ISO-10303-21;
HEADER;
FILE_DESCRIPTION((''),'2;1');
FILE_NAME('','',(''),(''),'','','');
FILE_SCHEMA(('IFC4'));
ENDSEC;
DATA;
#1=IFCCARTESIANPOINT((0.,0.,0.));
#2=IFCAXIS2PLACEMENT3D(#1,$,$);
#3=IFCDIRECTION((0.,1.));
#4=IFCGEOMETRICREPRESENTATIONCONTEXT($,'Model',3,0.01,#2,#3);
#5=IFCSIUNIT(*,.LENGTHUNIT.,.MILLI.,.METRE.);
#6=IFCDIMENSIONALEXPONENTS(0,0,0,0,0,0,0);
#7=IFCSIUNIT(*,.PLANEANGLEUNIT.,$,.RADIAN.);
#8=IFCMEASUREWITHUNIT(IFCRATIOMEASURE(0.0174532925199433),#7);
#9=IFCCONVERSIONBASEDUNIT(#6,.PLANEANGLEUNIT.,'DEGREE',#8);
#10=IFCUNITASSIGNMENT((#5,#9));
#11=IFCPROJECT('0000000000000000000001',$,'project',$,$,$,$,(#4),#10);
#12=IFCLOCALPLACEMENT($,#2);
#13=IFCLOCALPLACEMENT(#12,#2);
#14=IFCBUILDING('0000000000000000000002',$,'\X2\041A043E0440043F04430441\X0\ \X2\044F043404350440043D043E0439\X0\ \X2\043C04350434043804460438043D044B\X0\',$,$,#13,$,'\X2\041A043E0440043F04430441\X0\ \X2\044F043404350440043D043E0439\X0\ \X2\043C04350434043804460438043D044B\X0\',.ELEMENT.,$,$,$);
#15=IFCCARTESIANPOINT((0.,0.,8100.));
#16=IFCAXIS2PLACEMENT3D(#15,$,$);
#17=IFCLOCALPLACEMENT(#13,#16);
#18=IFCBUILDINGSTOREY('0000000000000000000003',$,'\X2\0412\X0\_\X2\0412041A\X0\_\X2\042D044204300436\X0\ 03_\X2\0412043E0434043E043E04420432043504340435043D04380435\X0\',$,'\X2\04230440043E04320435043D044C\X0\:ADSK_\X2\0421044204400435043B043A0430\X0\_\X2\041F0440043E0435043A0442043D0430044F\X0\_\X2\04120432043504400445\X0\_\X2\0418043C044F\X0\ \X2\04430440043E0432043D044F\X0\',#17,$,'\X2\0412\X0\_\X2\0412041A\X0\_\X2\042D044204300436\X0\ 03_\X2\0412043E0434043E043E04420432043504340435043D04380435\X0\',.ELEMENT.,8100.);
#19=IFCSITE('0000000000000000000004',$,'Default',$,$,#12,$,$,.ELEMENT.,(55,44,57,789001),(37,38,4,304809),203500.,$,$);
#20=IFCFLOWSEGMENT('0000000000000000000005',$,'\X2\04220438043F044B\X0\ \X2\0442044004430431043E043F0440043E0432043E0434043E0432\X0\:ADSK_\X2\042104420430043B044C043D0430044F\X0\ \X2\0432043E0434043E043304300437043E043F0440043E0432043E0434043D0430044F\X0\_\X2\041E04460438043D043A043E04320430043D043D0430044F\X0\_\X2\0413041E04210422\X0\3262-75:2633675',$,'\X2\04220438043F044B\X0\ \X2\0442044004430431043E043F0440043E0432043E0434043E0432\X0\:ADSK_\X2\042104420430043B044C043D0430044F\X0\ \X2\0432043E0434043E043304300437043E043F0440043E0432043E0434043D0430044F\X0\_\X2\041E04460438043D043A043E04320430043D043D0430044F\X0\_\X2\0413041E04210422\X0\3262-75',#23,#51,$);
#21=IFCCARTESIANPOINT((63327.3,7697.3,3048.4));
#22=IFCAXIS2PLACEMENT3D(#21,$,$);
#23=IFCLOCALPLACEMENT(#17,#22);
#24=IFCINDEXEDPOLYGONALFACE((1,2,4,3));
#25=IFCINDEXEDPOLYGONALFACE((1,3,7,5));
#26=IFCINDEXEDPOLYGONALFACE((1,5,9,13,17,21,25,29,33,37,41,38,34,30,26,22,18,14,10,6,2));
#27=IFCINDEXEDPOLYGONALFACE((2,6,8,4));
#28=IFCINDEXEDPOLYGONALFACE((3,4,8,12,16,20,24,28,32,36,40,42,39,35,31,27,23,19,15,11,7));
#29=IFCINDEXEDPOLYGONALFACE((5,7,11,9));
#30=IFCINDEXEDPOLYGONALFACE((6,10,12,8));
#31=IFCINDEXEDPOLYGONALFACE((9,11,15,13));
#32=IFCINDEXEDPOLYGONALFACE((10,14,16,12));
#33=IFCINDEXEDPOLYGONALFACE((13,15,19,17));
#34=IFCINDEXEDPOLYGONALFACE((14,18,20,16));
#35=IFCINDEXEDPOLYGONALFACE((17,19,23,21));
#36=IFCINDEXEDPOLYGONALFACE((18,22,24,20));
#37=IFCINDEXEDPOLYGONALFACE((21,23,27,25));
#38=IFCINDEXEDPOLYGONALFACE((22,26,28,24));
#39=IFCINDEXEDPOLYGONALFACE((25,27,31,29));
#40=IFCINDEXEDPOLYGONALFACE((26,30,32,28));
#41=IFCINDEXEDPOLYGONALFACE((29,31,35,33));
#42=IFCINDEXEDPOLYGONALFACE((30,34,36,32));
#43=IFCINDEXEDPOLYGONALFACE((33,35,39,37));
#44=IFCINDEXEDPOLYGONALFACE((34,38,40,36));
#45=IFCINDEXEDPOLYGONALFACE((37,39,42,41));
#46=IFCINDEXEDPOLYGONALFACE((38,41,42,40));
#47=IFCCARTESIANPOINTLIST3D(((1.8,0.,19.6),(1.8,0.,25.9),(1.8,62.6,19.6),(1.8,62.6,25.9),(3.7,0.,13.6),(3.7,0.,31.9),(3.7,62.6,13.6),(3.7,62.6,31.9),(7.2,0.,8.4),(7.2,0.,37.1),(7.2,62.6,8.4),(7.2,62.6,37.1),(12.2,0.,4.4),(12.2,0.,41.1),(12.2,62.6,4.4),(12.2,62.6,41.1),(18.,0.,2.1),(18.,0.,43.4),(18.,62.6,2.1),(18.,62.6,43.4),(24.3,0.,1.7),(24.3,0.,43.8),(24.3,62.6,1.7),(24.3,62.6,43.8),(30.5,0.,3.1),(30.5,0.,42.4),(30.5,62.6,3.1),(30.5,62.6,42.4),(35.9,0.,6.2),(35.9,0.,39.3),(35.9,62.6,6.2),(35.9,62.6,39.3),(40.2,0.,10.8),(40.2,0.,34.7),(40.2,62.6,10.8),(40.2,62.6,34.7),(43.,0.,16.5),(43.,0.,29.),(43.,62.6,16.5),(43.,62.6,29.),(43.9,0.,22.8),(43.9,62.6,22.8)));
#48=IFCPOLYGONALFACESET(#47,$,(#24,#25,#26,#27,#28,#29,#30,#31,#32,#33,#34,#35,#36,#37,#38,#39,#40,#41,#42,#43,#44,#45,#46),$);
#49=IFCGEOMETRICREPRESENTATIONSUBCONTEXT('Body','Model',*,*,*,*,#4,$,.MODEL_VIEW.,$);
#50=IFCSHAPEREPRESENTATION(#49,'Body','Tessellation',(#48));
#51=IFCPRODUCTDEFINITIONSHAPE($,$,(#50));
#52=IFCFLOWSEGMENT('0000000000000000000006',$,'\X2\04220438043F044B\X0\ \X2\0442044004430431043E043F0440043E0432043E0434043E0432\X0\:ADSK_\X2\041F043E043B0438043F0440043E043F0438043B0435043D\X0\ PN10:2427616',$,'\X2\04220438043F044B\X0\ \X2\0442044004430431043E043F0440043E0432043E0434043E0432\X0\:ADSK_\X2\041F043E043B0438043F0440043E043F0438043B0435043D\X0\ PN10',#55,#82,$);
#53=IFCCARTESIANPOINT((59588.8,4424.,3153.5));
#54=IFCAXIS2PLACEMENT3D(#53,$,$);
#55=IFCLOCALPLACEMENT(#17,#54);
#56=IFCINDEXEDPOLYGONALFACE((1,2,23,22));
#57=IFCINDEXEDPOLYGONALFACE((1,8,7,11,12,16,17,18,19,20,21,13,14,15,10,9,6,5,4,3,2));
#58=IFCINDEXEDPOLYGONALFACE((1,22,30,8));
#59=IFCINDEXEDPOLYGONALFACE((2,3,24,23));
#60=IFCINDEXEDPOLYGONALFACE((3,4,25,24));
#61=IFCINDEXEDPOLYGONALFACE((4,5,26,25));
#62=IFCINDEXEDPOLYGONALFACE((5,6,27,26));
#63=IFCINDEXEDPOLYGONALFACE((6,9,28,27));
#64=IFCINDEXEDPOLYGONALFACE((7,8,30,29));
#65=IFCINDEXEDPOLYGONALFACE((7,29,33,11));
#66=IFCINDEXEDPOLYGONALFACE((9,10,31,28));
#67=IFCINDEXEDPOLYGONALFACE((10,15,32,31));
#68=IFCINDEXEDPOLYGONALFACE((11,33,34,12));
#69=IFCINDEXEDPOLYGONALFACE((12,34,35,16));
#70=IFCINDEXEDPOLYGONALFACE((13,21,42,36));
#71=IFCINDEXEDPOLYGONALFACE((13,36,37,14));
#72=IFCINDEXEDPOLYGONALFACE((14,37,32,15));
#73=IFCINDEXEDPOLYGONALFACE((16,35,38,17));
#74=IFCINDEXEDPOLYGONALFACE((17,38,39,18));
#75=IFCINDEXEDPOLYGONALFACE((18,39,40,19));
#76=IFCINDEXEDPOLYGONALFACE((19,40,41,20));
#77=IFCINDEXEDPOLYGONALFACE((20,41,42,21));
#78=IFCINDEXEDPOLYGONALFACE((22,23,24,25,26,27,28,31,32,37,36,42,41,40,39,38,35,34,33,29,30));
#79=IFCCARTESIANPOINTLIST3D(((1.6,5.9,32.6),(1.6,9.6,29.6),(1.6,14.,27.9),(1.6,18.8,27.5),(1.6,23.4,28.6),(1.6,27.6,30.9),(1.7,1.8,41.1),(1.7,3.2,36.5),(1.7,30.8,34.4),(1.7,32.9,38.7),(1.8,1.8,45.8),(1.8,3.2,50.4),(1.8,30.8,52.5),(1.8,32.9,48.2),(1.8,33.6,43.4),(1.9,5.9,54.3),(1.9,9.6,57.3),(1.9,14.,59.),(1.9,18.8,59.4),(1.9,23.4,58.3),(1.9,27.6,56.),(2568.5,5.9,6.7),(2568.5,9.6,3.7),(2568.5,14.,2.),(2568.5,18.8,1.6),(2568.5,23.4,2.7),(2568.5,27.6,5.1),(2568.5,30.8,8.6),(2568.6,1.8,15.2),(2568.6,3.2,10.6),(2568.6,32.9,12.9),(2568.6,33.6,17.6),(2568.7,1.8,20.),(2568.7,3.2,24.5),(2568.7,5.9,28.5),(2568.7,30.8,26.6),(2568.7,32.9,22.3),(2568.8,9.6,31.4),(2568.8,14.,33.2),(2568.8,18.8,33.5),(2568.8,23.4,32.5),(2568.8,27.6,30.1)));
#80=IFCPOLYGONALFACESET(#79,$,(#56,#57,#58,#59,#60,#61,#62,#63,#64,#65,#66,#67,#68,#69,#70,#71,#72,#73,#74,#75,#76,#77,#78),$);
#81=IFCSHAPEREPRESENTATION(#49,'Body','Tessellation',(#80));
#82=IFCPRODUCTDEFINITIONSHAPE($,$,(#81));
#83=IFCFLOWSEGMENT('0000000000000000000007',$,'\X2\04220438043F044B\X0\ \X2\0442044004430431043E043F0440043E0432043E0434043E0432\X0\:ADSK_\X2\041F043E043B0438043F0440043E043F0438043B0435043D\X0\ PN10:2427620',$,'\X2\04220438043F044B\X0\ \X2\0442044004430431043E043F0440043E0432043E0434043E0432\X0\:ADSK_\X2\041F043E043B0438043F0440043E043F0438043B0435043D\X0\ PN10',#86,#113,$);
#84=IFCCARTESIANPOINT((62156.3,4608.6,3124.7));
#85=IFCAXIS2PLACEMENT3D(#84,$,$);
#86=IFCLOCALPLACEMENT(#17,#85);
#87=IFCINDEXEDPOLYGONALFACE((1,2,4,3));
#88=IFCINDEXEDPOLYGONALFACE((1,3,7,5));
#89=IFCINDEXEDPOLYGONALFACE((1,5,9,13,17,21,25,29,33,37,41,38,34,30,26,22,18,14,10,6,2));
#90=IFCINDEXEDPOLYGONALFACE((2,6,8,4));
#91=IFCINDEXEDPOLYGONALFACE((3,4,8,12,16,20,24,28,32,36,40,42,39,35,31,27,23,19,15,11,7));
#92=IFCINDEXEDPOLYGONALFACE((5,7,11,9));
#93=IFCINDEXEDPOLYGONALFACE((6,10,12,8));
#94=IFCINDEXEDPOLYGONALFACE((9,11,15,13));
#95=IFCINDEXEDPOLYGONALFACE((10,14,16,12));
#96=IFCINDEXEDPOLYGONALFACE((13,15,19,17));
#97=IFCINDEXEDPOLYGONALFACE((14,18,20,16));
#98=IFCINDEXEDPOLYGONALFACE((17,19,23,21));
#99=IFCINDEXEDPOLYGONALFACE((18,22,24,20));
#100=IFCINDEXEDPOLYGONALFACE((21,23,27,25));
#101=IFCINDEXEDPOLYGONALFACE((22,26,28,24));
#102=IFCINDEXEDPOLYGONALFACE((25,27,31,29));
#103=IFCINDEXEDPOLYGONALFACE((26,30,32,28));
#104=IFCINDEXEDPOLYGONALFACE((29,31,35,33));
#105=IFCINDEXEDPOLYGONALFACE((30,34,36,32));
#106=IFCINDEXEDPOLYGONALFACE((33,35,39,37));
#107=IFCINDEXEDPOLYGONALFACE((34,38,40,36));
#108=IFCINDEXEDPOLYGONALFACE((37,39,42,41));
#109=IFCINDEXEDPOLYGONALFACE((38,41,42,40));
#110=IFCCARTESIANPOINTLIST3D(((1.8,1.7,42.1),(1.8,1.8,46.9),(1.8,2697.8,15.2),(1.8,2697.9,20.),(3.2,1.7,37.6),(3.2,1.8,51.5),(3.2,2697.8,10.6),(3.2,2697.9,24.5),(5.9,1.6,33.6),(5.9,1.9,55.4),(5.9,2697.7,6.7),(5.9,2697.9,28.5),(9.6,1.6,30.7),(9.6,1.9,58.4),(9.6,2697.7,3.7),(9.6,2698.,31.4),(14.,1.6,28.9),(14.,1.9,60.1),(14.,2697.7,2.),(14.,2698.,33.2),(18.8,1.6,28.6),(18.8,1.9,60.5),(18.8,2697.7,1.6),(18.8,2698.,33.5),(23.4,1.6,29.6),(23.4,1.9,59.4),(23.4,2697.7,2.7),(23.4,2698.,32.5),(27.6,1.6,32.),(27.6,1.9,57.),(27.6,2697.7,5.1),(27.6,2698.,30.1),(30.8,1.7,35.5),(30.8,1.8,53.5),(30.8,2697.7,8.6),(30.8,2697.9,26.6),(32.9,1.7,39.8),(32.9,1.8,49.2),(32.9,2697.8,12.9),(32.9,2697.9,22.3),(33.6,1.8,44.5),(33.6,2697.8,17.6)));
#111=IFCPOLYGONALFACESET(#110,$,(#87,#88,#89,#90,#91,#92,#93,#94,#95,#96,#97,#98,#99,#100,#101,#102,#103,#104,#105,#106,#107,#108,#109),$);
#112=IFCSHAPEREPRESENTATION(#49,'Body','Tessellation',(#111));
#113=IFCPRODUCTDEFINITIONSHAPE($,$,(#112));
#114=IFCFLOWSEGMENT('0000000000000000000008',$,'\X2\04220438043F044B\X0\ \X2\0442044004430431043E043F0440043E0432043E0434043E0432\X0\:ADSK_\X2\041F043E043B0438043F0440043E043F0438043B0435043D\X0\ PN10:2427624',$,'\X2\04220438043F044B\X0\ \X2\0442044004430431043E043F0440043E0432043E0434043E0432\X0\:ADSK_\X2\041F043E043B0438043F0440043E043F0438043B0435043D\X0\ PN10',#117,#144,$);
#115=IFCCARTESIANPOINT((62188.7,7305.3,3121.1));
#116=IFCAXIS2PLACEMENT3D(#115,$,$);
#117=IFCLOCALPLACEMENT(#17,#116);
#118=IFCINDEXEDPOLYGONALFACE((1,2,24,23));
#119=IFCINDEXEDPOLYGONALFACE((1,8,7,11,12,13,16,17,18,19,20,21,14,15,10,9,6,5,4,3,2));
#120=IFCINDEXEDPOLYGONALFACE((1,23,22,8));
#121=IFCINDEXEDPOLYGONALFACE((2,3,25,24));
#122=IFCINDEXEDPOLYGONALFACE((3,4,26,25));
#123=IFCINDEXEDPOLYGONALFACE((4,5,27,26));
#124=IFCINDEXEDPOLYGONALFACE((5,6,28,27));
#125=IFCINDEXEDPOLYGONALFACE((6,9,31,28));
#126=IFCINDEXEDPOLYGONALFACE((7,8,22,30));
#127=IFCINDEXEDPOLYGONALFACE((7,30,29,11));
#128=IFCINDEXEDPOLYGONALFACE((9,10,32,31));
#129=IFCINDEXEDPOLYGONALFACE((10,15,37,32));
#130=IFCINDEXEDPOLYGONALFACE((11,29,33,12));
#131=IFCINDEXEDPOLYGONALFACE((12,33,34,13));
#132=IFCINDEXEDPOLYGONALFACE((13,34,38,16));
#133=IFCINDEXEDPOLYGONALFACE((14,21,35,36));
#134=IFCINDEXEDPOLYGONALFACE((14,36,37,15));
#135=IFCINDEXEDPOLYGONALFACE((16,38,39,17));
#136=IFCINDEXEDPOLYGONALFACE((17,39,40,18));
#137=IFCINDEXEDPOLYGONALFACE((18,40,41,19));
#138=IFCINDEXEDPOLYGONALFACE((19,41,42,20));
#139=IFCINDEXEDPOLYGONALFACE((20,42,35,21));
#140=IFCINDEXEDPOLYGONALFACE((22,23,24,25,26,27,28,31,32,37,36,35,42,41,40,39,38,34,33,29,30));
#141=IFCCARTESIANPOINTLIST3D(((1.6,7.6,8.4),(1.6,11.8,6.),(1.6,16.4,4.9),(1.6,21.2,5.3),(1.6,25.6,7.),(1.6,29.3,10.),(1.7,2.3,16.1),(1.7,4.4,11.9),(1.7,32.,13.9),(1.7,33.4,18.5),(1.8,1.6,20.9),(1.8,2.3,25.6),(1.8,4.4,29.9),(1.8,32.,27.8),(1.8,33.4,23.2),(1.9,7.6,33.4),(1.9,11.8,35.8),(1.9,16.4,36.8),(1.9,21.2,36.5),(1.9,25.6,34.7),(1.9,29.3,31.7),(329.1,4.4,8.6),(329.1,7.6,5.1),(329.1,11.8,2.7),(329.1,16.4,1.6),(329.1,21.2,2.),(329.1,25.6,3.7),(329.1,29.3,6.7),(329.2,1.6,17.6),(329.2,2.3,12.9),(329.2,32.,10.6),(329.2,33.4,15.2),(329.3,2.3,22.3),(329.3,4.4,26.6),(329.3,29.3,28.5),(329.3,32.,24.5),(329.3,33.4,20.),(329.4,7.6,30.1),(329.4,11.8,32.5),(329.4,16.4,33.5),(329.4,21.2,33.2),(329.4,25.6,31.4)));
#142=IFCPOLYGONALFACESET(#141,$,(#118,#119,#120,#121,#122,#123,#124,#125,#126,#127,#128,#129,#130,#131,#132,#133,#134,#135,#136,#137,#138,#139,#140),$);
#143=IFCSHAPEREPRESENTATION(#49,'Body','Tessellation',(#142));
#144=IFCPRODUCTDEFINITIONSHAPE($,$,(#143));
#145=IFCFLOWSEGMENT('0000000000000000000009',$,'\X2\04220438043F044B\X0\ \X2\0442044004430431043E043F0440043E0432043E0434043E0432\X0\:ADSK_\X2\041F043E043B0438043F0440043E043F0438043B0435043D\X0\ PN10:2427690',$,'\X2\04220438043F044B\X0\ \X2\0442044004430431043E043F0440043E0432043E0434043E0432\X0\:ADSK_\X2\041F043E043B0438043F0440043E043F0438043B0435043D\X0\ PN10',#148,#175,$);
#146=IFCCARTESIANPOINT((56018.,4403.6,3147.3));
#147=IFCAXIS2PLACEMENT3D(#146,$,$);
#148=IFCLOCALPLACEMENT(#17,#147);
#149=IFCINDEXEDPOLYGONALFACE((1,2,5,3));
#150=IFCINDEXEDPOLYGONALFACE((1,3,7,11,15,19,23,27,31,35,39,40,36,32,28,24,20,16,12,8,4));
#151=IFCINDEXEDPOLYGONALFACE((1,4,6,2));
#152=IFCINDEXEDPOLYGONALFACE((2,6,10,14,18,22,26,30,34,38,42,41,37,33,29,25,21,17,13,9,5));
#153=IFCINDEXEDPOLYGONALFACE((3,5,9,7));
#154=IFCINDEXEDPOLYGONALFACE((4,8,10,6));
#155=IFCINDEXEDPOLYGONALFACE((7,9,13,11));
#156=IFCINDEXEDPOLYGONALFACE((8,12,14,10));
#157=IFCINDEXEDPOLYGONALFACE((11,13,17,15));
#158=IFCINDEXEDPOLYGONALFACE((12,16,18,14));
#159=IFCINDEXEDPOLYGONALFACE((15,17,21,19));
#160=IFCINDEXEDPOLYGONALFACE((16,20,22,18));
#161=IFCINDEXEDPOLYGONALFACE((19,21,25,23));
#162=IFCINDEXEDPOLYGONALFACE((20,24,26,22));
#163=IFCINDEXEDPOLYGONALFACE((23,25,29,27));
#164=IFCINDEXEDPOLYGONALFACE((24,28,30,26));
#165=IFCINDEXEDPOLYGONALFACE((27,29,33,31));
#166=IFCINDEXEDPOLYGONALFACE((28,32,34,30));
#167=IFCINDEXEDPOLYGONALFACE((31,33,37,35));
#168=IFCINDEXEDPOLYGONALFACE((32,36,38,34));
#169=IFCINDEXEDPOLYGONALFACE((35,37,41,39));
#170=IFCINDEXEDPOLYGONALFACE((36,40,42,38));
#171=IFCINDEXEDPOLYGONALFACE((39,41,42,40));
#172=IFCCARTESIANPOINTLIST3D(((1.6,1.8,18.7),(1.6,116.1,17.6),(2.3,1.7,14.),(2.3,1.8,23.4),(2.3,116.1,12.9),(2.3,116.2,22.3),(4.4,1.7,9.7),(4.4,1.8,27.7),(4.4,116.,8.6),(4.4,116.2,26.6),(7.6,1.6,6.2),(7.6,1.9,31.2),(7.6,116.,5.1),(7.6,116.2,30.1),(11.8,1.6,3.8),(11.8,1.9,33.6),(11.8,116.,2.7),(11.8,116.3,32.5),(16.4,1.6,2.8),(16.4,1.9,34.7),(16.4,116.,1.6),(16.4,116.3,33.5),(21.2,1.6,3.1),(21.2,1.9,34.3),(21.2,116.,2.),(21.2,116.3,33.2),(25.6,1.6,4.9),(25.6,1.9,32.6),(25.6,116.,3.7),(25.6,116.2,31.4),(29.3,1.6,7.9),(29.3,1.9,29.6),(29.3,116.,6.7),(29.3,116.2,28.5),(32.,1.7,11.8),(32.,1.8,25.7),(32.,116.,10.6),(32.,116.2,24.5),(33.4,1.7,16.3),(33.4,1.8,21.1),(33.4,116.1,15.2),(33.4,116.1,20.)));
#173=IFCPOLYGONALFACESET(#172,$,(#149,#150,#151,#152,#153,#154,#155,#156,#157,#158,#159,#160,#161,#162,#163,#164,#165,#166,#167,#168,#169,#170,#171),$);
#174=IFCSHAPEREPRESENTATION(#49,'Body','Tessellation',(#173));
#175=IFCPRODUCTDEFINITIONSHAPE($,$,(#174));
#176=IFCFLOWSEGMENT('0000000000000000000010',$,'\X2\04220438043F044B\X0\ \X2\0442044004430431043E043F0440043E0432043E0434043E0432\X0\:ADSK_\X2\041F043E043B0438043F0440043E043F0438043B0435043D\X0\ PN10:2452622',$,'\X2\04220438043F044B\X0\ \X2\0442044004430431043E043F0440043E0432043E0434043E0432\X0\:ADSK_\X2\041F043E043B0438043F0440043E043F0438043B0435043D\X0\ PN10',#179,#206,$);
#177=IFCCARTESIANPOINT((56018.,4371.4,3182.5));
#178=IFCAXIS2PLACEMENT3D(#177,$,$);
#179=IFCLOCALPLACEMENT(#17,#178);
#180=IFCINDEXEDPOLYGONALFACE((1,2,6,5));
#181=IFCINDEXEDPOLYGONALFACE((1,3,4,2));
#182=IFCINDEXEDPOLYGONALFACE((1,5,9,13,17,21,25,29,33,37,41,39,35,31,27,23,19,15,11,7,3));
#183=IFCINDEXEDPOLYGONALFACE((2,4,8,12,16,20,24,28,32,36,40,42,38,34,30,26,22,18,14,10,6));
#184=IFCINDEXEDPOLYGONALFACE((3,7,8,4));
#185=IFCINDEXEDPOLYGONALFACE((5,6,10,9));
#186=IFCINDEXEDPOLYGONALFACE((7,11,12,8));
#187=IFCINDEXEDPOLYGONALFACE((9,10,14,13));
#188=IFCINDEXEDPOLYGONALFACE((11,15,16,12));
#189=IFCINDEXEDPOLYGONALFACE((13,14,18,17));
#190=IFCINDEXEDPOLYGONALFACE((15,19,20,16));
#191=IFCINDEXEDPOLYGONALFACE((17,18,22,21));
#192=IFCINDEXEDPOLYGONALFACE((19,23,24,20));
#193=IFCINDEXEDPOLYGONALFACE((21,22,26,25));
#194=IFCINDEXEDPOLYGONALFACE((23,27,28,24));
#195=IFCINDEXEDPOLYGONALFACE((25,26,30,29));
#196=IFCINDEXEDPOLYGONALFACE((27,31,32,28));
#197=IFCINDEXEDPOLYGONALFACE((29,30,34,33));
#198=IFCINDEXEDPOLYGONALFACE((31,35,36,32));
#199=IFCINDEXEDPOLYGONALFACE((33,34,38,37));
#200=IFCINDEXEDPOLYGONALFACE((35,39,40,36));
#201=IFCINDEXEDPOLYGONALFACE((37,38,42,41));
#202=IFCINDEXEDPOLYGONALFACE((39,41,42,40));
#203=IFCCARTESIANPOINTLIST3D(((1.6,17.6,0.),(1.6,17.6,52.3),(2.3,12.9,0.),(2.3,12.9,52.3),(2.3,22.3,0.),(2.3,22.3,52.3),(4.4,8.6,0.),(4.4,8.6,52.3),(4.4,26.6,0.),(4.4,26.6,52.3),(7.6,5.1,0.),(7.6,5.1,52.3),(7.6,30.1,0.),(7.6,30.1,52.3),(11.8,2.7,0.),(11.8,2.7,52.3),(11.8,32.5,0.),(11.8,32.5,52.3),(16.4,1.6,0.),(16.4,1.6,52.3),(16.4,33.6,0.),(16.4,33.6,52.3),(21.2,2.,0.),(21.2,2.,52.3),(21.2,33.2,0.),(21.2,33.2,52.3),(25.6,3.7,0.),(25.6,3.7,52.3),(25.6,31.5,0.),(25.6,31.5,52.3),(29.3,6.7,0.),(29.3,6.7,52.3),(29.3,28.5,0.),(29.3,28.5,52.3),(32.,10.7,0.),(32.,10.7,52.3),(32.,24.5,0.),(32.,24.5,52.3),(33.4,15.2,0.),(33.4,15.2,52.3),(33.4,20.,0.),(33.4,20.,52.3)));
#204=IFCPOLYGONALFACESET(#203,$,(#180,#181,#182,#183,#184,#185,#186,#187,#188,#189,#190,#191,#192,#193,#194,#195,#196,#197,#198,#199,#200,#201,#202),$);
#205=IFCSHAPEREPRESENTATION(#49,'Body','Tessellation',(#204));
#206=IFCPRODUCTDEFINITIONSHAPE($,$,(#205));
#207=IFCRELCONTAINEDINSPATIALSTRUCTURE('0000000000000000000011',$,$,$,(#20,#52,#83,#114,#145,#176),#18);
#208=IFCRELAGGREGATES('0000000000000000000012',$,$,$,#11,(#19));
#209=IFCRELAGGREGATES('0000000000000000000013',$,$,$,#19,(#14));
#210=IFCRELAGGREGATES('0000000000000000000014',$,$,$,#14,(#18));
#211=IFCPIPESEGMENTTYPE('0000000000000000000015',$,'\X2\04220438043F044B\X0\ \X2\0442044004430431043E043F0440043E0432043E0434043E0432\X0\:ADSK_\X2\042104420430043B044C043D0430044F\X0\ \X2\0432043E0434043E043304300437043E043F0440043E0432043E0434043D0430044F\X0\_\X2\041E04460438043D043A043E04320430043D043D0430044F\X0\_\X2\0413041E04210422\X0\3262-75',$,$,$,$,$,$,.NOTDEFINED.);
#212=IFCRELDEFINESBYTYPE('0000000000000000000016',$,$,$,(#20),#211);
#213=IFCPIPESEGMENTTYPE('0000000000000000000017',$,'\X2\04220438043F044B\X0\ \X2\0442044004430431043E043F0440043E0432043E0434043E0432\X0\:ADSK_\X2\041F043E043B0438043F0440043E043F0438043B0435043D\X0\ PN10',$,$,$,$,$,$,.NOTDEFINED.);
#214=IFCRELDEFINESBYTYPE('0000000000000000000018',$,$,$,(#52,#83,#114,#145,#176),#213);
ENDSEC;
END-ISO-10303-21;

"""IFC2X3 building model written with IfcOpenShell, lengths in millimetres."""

from ifc_helpers import new_model, entity, si_unit, converted_unit, direction, frame, origin, origin_2d_with_axis, place, context, subcontext, project, spatial, circle, extrude, type_object, element, save


model = new_model("IFC2X3")

# Units and contexts
model_context = context("Model", 3, precision=0.01, world=origin(), true_north=direction((0.0, 1.0)))
body_context = subcontext(model_context, "Body", "Model", "MODEL_VIEW")
ifc_project = project(units=[si_unit("LENGTHUNIT", "METRE", prefix="MILLI"), converted_unit("PLANEANGLEUNIT", "DEGREE", entity("IfcRatioMeasure", 0.0174532925199433), si_unit("PLANEANGLEUNIT", "RADIAN"), dimensions=[0, 0, 0, 0, 0, 0, 0])], contexts=[model_context])

# Site, building, storey
site_placement = place(None, origin())
site = spatial("IfcSite", under=ifc_project, at=site_placement, Name="Default", CompositionType="ELEMENT", RefLatitude=(55, 44, 57, 789001), RefLongitude=(37, 38, 4, 304809), RefElevation=203500.0)
building_placement = place(site_placement, origin())
building = spatial("IfcBuilding", under=site, at=building_placement, Name="Корпус ядерной медицины", LongName="Корпус ядерной медицины", CompositionType="ELEMENT")
storey_placement = place(building_placement, frame((0.0, 0.0, 8100.0)))
storey = spatial("IfcBuildingStorey", under=building, at=storey_placement, Name="В_ВК_Этаж 03_Водоотведение", ObjectType="Уровень:ADSK_Стрелка_Проектная_Вверх_Имя уровня", LongName="В_ВК_Этаж 03_Водоотведение", CompositionType="ELEMENT", Elevation=8100.0)

# Flow segments
pipe_segment_type_1 = type_object("IfcPipeSegmentType", Name="Типы трубопроводов:ADSK_Стальная водогазопроводная_Оцинкованная_ГОСТ3262-75", PredefinedType="NOTDEFINED")
flow_segment_1_placement = place(storey_placement, frame((63327.3, 7697.3, 3048.4)))
element("IfcFlowSegment", 1, at=flow_segment_1_placement, inside=storey, type_object=pipe_segment_type_1, Name="Типы трубопроводов:ADSK_Стальная водогазопроводная_Оцинкованная_ГОСТ3262-75:2633675", ObjectType="Типы трубопроводов:ADSK_Стальная водогазопроводная_Оцинкованная_ГОСТ3262-75", context=body_context, shape_type="SweptSolid", body=[
    extrude(circle(Radius=21.1, at=origin_2d_with_axis()), frame((22.8, 0.0, 22.8), z_axis=(0.0, 1.0, 0.0), x_axis=(1.0, 0.0, 0.0)), (0.0, 0.0, 1.0), 62.6),
])
pipe_segment_type_2 = type_object("IfcPipeSegmentType", Name="Типы трубопроводов:ADSK_Полипропилен PN10", PredefinedType="NOTDEFINED")
flow_segment_2_placement = place(storey_placement, frame((59588.8, 4424.0, 3153.5)))
element("IfcFlowSegment", 2, at=flow_segment_2_placement, inside=storey, type_object=pipe_segment_type_2, Name="Типы трубопроводов:ADSK_Полипропилен PN10:2427616", ObjectType="Типы трубопроводов:ADSK_Полипропилен PN10", context=body_context, shape_type="SweptSolid", body=[
    extrude(circle(Radius=16.0, at=origin_2d_with_axis()), frame((2568.6, 17.6, 17.6), z_axis=(-0.999949, 0.0, 0.010074), x_axis=(0.0, 1.0, 0.0)), (0.0, 0.0, 1.0), 2567.0),
])
flow_segment_3_placement = place(storey_placement, frame((62156.3, 4608.6, 3124.7)))
element("IfcFlowSegment", 3, at=flow_segment_3_placement, inside=storey, type_object=pipe_segment_type_2, Name="Типы трубопроводов:ADSK_Полипропилен PN10:2427620", ObjectType="Типы трубопроводов:ADSK_Полипропилен PN10", context=body_context, shape_type="SweptSolid", body=[
    extrude(circle(Radius=16.0, at=origin_2d_with_axis()), frame((17.6, 2697.8, 17.6), z_axis=(0.0, -0.99995, 0.00999), x_axis=(1.0, 0.0, 0.0)), (0.0, 0.0, 1.0), 2696.2),
])
flow_segment_4_placement = place(storey_placement, frame((62188.7, 7305.3, 3121.1)))
element("IfcFlowSegment", 4, at=flow_segment_4_placement, inside=storey, type_object=pipe_segment_type_2, Name="Типы трубопроводов:ADSK_Полипропилен PN10:2427624", ObjectType="Типы трубопроводов:ADSK_Полипропилен PN10", context=body_context, shape_type="SweptSolid", body=[
    extrude(circle(Radius=16.0, at=origin_2d_with_axis()), frame((329.2, 17.6, 17.6), z_axis=(-0.99995, 0.0, 0.01), x_axis=(0.0, -1.0, 0.0)), (0.0, 0.0, 1.0), 327.5),
])
flow_segment_5_placement = place(storey_placement, frame((56018.0, 4403.6, 3147.3)))
element("IfcFlowSegment", 5, at=flow_segment_5_placement, inside=storey, type_object=pipe_segment_type_2, Name="Типы трубопроводов:ADSK_Полипропилен PN10:2427690", ObjectType="Типы трубопроводов:ADSK_Полипропилен PN10", context=body_context, shape_type="SweptSolid", body=[
    extrude(circle(Radius=16.0, at=origin_2d_with_axis()), frame((17.6, 116.1, 17.6), z_axis=(0.0, -0.99995, 0.01), x_axis=(-1.0, 0.0, 0.0)), (0.0, 0.0, 1.0), 114.4),
])
flow_segment_6_placement = place(storey_placement, frame((56018.0, 4371.4, 3182.5)))
element("IfcFlowSegment", 6, at=flow_segment_6_placement, inside=storey, type_object=pipe_segment_type_2, Name="Типы трубопроводов:ADSK_Полипропилен PN10:2452622", ObjectType="Типы трубопроводов:ADSK_Полипропилен PN10", context=body_context, shape_type="SweptSolid", body=[
    extrude(circle(Radius=16.0, at=origin_2d_with_axis()), frame((17.6, 17.6, 0.0), z_axis=(0.0, 0.0, 1.0), x_axis=(-1.0, 0.0, 0.0)), (0.0, 0.0, 1.0), 52.3),
])

save(model, "model.ifc")
